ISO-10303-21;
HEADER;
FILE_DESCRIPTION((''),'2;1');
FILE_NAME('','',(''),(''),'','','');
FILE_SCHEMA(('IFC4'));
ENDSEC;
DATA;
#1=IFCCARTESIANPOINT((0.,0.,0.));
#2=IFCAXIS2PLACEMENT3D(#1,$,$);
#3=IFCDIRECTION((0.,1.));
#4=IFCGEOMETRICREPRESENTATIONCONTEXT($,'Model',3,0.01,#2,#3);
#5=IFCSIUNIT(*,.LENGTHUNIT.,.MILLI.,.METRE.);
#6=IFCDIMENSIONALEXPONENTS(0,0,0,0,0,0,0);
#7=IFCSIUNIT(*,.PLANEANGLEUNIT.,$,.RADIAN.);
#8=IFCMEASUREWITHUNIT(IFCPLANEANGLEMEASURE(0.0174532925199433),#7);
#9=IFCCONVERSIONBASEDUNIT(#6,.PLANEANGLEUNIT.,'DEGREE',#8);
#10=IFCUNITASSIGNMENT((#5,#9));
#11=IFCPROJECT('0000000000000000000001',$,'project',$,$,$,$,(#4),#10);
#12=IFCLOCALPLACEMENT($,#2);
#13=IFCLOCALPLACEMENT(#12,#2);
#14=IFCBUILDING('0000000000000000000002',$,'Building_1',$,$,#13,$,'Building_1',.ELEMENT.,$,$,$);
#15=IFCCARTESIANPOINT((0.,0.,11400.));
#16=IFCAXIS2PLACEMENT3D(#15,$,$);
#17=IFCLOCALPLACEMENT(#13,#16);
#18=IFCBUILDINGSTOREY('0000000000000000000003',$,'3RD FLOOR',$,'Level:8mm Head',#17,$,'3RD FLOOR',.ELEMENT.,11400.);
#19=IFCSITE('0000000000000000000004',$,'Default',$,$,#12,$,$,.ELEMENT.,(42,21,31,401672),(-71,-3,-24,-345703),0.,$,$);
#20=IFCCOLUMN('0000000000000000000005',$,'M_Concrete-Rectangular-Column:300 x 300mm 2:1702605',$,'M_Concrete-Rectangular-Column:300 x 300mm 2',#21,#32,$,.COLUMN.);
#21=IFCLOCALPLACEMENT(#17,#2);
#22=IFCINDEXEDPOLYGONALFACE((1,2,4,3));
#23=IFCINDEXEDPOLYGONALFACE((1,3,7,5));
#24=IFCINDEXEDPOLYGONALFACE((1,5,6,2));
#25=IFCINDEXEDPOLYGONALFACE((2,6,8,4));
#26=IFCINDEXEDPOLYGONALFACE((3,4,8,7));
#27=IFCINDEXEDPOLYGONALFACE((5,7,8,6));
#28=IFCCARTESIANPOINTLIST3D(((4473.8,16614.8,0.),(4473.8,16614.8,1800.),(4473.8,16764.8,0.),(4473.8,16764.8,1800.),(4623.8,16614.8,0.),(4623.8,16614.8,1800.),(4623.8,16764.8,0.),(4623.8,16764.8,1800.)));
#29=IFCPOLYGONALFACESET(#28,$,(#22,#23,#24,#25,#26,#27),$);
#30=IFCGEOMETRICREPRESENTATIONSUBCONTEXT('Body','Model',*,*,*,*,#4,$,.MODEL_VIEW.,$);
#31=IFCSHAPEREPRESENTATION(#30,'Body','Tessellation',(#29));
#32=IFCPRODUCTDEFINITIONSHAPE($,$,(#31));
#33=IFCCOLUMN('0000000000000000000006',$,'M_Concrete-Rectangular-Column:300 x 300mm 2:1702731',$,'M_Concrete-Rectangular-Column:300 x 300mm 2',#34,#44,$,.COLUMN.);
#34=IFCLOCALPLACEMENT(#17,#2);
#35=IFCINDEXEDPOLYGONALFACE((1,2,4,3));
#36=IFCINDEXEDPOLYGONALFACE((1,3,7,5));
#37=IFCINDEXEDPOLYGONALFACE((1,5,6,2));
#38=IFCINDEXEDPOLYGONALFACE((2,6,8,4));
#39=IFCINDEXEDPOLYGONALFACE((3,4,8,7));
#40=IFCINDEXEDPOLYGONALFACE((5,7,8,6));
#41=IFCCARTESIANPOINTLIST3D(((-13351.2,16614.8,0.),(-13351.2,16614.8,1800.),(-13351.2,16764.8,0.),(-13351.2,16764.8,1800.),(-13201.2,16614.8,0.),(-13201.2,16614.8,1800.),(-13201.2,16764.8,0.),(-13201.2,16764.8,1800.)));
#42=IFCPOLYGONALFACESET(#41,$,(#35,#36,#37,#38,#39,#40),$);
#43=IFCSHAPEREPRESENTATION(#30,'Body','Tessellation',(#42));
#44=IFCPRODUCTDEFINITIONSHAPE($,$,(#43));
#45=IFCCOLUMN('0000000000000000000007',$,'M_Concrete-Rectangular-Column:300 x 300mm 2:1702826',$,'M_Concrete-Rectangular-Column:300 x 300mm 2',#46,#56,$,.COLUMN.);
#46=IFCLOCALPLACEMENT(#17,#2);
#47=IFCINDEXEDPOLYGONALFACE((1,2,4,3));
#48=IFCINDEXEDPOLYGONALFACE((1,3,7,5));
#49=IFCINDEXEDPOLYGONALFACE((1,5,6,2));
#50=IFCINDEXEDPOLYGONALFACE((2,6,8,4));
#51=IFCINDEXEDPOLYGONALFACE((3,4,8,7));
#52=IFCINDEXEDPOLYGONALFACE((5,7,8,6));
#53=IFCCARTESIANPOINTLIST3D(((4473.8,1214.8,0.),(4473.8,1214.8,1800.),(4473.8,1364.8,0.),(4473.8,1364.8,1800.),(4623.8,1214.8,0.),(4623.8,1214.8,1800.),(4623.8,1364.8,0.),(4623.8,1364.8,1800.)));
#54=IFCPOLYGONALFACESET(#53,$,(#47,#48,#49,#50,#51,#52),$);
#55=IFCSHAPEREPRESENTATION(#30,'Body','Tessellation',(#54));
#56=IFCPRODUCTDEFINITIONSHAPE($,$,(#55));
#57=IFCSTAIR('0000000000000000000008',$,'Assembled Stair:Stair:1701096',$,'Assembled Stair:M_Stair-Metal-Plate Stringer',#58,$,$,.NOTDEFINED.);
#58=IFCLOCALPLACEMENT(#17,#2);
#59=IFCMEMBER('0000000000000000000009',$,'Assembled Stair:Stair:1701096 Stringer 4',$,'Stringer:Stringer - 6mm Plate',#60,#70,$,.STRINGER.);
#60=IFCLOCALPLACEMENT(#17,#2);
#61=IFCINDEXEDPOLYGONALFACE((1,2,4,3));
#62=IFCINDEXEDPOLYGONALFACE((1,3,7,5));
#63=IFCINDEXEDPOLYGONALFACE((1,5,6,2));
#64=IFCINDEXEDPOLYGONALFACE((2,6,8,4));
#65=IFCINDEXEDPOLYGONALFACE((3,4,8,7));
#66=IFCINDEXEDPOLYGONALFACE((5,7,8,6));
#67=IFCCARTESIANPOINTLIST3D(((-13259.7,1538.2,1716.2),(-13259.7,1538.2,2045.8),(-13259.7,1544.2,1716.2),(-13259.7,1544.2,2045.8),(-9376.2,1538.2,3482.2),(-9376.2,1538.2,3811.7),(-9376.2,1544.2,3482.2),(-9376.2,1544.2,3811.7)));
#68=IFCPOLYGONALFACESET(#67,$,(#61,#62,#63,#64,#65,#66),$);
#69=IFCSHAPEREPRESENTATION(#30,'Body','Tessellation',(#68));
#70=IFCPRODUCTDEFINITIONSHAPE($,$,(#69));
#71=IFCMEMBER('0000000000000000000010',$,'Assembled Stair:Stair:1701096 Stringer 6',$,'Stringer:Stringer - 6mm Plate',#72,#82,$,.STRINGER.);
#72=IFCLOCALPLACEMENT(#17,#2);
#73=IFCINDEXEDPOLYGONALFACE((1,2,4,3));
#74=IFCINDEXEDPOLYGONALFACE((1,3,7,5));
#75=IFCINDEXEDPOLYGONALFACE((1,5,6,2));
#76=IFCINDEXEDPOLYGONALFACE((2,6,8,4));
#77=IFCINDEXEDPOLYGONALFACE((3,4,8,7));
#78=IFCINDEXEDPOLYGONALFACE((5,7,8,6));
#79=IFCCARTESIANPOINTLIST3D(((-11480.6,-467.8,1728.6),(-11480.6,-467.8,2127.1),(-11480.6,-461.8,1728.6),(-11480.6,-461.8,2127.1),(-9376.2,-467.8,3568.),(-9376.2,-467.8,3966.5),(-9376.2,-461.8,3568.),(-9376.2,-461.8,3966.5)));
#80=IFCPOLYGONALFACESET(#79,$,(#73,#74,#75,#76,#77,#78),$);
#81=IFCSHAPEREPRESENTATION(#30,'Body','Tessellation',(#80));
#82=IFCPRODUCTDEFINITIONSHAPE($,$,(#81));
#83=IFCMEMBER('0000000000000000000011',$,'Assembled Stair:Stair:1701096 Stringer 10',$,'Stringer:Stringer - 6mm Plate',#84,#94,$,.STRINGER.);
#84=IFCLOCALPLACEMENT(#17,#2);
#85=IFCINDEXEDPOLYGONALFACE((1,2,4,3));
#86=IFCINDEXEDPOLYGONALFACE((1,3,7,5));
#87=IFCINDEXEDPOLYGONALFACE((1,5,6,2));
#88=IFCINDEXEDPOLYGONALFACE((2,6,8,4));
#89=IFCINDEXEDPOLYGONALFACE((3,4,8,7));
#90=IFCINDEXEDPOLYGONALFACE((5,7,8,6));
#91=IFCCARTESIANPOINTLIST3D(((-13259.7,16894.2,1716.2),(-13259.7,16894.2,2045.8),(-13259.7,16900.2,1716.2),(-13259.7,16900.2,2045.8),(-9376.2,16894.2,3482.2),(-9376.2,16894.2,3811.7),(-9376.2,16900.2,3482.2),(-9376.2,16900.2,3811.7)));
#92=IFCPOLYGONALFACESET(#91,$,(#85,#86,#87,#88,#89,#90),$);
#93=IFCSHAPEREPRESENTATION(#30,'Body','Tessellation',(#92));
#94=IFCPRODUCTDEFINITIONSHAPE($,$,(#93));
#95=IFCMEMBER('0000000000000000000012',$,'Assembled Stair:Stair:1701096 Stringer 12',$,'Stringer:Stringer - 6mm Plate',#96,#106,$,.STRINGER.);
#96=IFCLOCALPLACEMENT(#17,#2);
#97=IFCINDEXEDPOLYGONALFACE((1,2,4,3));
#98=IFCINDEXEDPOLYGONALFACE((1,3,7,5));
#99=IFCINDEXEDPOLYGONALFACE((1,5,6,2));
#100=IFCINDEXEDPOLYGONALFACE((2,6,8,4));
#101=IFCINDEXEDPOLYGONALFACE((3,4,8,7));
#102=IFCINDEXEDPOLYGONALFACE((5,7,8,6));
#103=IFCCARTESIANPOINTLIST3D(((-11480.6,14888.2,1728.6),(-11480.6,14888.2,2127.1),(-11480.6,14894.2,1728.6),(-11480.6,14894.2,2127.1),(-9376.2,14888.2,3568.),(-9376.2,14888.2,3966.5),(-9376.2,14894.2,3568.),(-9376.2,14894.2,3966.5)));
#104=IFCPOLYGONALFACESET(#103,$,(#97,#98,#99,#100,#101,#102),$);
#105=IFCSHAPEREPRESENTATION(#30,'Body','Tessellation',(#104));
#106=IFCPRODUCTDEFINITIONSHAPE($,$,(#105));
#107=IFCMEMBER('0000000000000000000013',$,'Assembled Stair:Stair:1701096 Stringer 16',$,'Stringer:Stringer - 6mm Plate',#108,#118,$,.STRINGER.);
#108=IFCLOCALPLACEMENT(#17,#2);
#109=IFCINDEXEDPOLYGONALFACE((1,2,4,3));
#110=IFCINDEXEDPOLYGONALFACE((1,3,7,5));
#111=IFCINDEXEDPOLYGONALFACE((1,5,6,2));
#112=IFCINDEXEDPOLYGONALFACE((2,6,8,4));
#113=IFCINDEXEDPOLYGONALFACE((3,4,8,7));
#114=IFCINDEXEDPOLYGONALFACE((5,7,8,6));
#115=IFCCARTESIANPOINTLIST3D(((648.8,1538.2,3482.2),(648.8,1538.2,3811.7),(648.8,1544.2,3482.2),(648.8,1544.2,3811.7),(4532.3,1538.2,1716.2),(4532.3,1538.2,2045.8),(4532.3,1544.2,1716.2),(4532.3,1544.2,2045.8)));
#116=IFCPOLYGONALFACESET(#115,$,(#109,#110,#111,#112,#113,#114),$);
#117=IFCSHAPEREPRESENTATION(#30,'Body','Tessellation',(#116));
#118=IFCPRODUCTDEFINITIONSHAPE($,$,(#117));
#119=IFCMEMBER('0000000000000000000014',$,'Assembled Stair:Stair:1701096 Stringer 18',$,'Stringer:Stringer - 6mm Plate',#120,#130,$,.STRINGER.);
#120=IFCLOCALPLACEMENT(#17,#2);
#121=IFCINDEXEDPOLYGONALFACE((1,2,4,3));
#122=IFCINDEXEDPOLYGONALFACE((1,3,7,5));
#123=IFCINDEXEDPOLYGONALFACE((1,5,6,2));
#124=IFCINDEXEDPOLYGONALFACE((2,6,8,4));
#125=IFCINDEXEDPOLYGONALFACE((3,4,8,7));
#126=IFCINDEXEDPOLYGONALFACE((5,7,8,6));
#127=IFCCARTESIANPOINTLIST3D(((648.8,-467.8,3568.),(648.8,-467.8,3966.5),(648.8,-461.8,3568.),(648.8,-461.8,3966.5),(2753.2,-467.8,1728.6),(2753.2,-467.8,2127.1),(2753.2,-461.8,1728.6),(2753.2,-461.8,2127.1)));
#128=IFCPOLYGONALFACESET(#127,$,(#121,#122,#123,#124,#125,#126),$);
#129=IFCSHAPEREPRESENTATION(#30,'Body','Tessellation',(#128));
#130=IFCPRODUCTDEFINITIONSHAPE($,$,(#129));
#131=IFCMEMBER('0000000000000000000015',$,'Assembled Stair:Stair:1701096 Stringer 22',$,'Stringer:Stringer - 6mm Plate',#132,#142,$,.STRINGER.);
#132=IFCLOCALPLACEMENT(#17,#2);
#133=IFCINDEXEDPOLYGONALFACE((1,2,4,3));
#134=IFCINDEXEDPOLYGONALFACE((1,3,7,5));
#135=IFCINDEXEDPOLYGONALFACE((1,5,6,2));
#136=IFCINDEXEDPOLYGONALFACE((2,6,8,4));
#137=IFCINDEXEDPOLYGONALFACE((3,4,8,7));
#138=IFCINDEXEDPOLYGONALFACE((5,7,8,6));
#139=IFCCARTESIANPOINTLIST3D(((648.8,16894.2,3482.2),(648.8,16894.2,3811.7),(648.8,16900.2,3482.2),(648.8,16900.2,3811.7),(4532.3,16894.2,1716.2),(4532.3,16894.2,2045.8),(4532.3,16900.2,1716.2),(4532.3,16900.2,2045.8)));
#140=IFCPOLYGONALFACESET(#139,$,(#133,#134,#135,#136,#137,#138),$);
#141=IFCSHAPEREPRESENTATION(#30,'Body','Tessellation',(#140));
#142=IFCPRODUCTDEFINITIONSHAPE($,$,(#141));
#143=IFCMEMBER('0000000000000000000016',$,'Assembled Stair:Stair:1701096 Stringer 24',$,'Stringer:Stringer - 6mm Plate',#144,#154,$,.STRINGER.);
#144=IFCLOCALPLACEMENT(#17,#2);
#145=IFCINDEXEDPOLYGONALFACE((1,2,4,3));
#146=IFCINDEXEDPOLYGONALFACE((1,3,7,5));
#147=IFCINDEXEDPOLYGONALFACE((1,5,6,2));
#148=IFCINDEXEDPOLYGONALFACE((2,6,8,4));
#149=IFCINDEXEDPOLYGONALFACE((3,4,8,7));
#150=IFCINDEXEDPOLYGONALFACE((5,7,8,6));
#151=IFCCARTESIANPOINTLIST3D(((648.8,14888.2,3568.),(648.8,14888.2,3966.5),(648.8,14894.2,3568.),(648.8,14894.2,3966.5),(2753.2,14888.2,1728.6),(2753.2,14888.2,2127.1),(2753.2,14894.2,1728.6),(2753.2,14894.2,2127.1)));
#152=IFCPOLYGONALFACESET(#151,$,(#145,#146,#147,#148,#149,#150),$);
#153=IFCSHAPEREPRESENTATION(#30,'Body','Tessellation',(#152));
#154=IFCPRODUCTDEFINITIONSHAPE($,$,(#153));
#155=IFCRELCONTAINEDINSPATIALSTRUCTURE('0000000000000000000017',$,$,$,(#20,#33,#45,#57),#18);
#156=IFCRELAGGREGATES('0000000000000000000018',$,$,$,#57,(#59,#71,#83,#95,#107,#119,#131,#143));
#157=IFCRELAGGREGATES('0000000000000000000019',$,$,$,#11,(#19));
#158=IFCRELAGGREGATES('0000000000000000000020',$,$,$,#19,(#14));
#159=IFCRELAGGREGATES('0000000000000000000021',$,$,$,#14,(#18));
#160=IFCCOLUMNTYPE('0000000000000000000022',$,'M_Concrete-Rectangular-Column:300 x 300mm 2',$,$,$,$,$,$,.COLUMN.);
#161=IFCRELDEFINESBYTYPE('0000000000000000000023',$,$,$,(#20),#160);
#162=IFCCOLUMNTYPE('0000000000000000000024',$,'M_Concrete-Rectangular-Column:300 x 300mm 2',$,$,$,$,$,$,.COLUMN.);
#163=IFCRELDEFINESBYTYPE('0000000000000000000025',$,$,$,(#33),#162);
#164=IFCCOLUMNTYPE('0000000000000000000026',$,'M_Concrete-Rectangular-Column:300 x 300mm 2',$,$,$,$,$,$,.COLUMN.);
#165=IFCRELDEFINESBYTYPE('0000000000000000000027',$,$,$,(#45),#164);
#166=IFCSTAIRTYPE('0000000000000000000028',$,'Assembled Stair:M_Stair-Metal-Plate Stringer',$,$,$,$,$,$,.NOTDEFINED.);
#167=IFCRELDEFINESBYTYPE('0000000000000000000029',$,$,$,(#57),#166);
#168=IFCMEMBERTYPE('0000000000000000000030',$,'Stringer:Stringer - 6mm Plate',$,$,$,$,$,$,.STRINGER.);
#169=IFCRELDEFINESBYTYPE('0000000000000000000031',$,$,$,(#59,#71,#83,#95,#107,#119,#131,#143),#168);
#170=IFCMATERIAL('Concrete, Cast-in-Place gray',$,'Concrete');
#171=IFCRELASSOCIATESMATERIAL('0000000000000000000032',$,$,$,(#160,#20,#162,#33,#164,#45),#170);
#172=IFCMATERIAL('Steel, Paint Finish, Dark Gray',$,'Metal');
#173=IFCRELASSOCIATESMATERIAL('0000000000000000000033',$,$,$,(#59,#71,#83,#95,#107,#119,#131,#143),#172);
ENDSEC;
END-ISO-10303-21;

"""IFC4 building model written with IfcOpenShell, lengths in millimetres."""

from ifc_helpers import new_model, entity, si_unit, converted_unit, direction, frame, origin, place, context, subcontext, project, spatial, indexed_curve, outline, extrude, source, transform, mapped, material, type_object, type_shapes, element, aggregate, save


model = new_model("IFC4")

# Units and contexts
model_context = context("Model", 3, precision=0.01, world=origin(), true_north=direction((0.0, 1.0)))
body_context = subcontext(model_context, "Body", "Model", "MODEL_VIEW")
ifc_project = project(units=[si_unit("LENGTHUNIT", "METRE", prefix="MILLI"), converted_unit("PLANEANGLEUNIT", "DEGREE", entity("IfcPlaneAngleMeasure", 0.0174532925199433), si_unit("PLANEANGLEUNIT", "RADIAN"), dimensions=[0, 0, 0, 0, 0, 0, 0])], contexts=[model_context])

# Site, building, storey
site_placement = place(None, origin())
site = spatial("IfcSite", under=ifc_project, at=site_placement, Name="Default", CompositionType="ELEMENT", RefLatitude=(42, 21, 31, 401672), RefLongitude=(-71, -3, -24, -345703), RefElevation=0.0)
building_placement = place(site_placement, origin())
building = spatial("IfcBuilding", under=site, at=building_placement, Name="Building_1", LongName="Building_1", CompositionType="ELEMENT")
storey_placement = place(building_placement, frame((0.0, 0.0, 11400.0)))
storey = spatial("IfcBuildingStorey", under=building, at=storey_placement, Name="3RD FLOOR", ObjectType="Level:8mm Head", LongName="3RD FLOOR", CompositionType="ELEMENT", Elevation=11400.0)

# Columns
ifc_material_1 = material(Name="Concrete, Cast-in-Place gray", Category="Concrete")
column_type_1 = type_object("IfcColumnType", Name="M_Concrete-Rectangular-Column:300 x 300mm 2", PredefinedType="COLUMN", material=ifc_material_1)
shared_shape_1 = source(origin(), body_context, "Body", "SweptSolid", [
    extrude(outline(indexed_curve([(-75.0, -75.0), (75.0, -75.0), (75.0, 75.0), (-75.0, 75.0), (-75.0, -75.0)], self_intersect=False)), frame((4548.8, 16689.8, 11400.0), z_axis=(0.0, 0.0, 1.0), x_axis=(-1.0, 0.0, 0.0)), (0.0, 0.0, 1.0), 1800.0),
])
type_shapes(column_type_1, [shared_shape_1])
column_1_placement = place(storey_placement, frame((0.0, 0.0, -11400.0)))
element("IfcColumn", 1, at=column_1_placement, inside=storey, type_object=column_type_1, material=ifc_material_1, Name="M_Concrete-Rectangular-Column:300 x 300mm 2:1702605", ObjectType="M_Concrete-Rectangular-Column:300 x 300mm 2", PredefinedType="COLUMN", context=body_context, shape_type="MappedRepresentation", body=[
    mapped(shared_shape_1, transform((0.0, 0.0, 0.0), scale=1.0)),
])
column_type_2 = type_object("IfcColumnType", Name="M_Concrete-Rectangular-Column:300 x 300mm 2", PredefinedType="COLUMN", material=ifc_material_1)
shared_shape_2 = source(origin(), body_context, "Body", "SweptSolid", [
    extrude(outline(indexed_curve([(-75.0, -75.0), (75.0, -75.0), (75.0, 75.0), (-75.0, 75.0), (-75.0, -75.0)], self_intersect=False)), frame((-13276.2, 16689.8, 11400.0), z_axis=(0.0, 0.0, 1.0), x_axis=(-1.0, 0.0, 0.0)), (0.0, 0.0, 1.0), 1800.0),
])
type_shapes(column_type_2, [shared_shape_2])
column_2_placement = place(storey_placement, frame((0.0, 0.0, -11400.0)))
element("IfcColumn", 2, at=column_2_placement, inside=storey, type_object=column_type_2, material=ifc_material_1, Name="M_Concrete-Rectangular-Column:300 x 300mm 2:1702731", ObjectType="M_Concrete-Rectangular-Column:300 x 300mm 2", PredefinedType="COLUMN", context=body_context, shape_type="MappedRepresentation", body=[
    mapped(shared_shape_2, transform((0.0, 0.0, 0.0), scale=1.0)),
])
column_type_3 = type_object("IfcColumnType", Name="M_Concrete-Rectangular-Column:300 x 300mm 2", PredefinedType="COLUMN", material=ifc_material_1)
shared_shape_3 = source(origin(), body_context, "Body", "SweptSolid", [
    extrude(outline(indexed_curve([(-75.0, -75.0), (75.0, -75.0), (75.0, 75.0), (-75.0, 75.0), (-75.0, -75.0)], self_intersect=False)), frame((4548.8, 1289.8, 11400.0), z_axis=(0.0, 0.0, 1.0), x_axis=(-1.0, 0.0, 0.0)), (0.0, 0.0, 1.0), 1800.0),
])
type_shapes(column_type_3, [shared_shape_3])
column_3_placement = place(storey_placement, frame((0.0, 0.0, -11400.0)))
element("IfcColumn", 3, at=column_3_placement, inside=storey, type_object=column_type_3, material=ifc_material_1, Name="M_Concrete-Rectangular-Column:300 x 300mm 2:1702826", ObjectType="M_Concrete-Rectangular-Column:300 x 300mm 2", PredefinedType="COLUMN", context=body_context, shape_type="MappedRepresentation", body=[
    mapped(shared_shape_3, transform((0.0, 0.0, 0.0), scale=1.0)),
])

# Stair, members
stair_type = type_object("IfcStairType", Name="Assembled Stair:M_Stair-Metal-Plate Stringer", PredefinedType="NOTDEFINED")
stair_placement = place(storey_placement, origin())
stair = element("IfcStair", 4, at=stair_placement, inside=storey, type_object=stair_type, Name="Assembled Stair:Stair:1701096", ObjectType="Assembled Stair:M_Stair-Metal-Plate Stringer", PredefinedType="NOTDEFINED")
ifc_material_2 = material(Name="Steel, Paint Finish, Dark Gray", Category="Metal")
member_type = type_object("IfcMemberType", Name="Stringer:Stringer - 6mm Plate", PredefinedType="STRINGER")
member_1_placement = place(stair_placement, origin())
member_1 = element("IfcMember", 5, at=member_1_placement, type_object=member_type, material=ifc_material_2, Name="Assembled Stair:Stair:1701096 Stringer 4", ObjectType="Stringer:Stringer - 6mm Plate", PredefinedType="STRINGER", context=body_context, shape_type="SweptSolid", body=[
    extrude(outline(indexed_curve([(-2064.9, -150.0), (2201.3, -150.0), (2064.9, 150.0), (-2201.3, 150.0), (-2064.9, -150.0)], self_intersect=False)), frame((-11317.9, 1538.2, 2764.0), z_axis=(0.0, 1.0, 0.0), x_axis=(0.910301, 0.0, 0.413948)), (0.0, 0.0, 1.0), 6.0),
])
member_2_placement = place(stair_placement, origin())
member_2 = element("IfcMember", 6, at=member_2_placement, type_object=member_type, material=ifc_material_2, Name="Assembled Stair:Stair:1701096 Stringer 6", ObjectType="Stringer:Stringer - 6mm Plate", PredefinedType="STRINGER", context=body_context, shape_type="SweptSolid", body=[
    extrude(outline(indexed_curve([(-1266.4, -150.0), (1528.6, -150.0), (1266.4, 150.0), (-1528.6, 150.0), (-1266.4, -150.0)], self_intersect=False)), frame((-10428.4, -467.8, 2847.6), z_axis=(0.0, 1.0, 0.0), x_axis=(0.752918, 0.0, 0.658114)), (0.0, 0.0, 1.0), 6.0),
])
member_3_placement = place(stair_placement, origin())
member_3 = element("IfcMember", 7, at=member_3_placement, type_object=member_type, material=ifc_material_2, Name="Assembled Stair:Stair:1701096 Stringer 10", ObjectType="Stringer:Stringer - 6mm Plate", PredefinedType="STRINGER", context=body_context, shape_type="SweptSolid", body=[
    extrude(outline(indexed_curve([(-2064.9, -150.0), (2201.3, -150.0), (2064.9, 150.0), (-2201.3, 150.0), (-2064.9, -150.0)], self_intersect=False)), frame((-11317.9, 16894.2, 2764.0), z_axis=(0.0, 1.0, 0.0), x_axis=(0.910301, 0.0, 0.413948)), (0.0, 0.0, 1.0), 6.0),
])
member_4_placement = place(stair_placement, origin())
member_4 = element("IfcMember", 8, at=member_4_placement, type_object=member_type, material=ifc_material_2, Name="Assembled Stair:Stair:1701096 Stringer 12", ObjectType="Stringer:Stringer - 6mm Plate", PredefinedType="STRINGER", context=body_context, shape_type="SweptSolid", body=[
    extrude(outline(indexed_curve([(-1266.4, -150.0), (1528.6, -150.0), (1266.4, 150.0), (-1528.6, 150.0), (-1266.4, -150.0)], self_intersect=False)), frame((-10428.4, 14888.2, 2847.6), z_axis=(0.0, 1.0, 0.0), x_axis=(0.752918, 0.0, 0.658114)), (0.0, 0.0, 1.0), 6.0),
])
member_5_placement = place(stair_placement, origin())
member_5 = element("IfcMember", 9, at=member_5_placement, type_object=member_type, material=ifc_material_2, Name="Assembled Stair:Stair:1701096 Stringer 16", ObjectType="Stringer:Stringer - 6mm Plate", PredefinedType="STRINGER", context=body_context, shape_type="SweptSolid", body=[
    extrude(outline(indexed_curve([(-2201.3, -150.0), (2064.9, -150.0), (2201.3, 150.0), (-2064.9, 150.0), (-2201.3, -150.0)], self_intersect=False)), frame((2590.5, 1538.2, 2764.0), z_axis=(0.0, 1.0, 0.0), x_axis=(-0.910301, 0.0, 0.413948)), (0.0, 0.0, 1.0), 6.0),
])
member_6_placement = place(stair_placement, origin())
member_6 = element("IfcMember", 10, at=member_6_placement, type_object=member_type, material=ifc_material_2, Name="Assembled Stair:Stair:1701096 Stringer 18", ObjectType="Stringer:Stringer - 6mm Plate", PredefinedType="STRINGER", context=body_context, shape_type="SweptSolid", body=[
    extrude(outline(indexed_curve([(-1528.6, -150.0), (1266.4, -150.0), (1528.6, 150.0), (-1266.4, 150.0), (-1528.6, -150.0)], self_intersect=False)), frame((1701.0, -467.8, 2847.6), z_axis=(0.0, 1.0, 0.0), x_axis=(-0.752918, 0.0, 0.658114)), (0.0, 0.0, 1.0), 6.0),
])
member_7_placement = place(stair_placement, origin())
member_7 = element("IfcMember", 11, at=member_7_placement, type_object=member_type, material=ifc_material_2, Name="Assembled Stair:Stair:1701096 Stringer 22", ObjectType="Stringer:Stringer - 6mm Plate", PredefinedType="STRINGER", context=body_context, shape_type="SweptSolid", body=[
    extrude(outline(indexed_curve([(-2201.3, -150.0), (2064.9, -150.0), (2201.3, 150.0), (-2064.9, 150.0), (-2201.3, -150.0)], self_intersect=False)), frame((2590.5, 16894.2, 2764.0), z_axis=(0.0, 1.0, 0.0), x_axis=(-0.910301, 0.0, 0.413948)), (0.0, 0.0, 1.0), 6.0),
])
member_8_placement = place(stair_placement, origin())
member_8 = element("IfcMember", 12, at=member_8_placement, type_object=member_type, material=ifc_material_2, Name="Assembled Stair:Stair:1701096 Stringer 24", ObjectType="Stringer:Stringer - 6mm Plate", PredefinedType="STRINGER", context=body_context, shape_type="SweptSolid", body=[
    extrude(outline(indexed_curve([(-1528.6, -150.0), (1266.4, -150.0), (1528.6, 150.0), (-1266.4, 150.0), (-1528.6, -150.0)], self_intersect=False)), frame((1701.0, 14888.2, 2847.6), z_axis=(0.0, 1.0, 0.0), x_axis=(-0.752918, 0.0, 0.658114)), (0.0, 0.0, 1.0), 6.0),
])
aggregate(stair, [member_1, member_2, member_3, member_4, member_5, member_6, member_7, member_8])

save(model, "model.ifc")
